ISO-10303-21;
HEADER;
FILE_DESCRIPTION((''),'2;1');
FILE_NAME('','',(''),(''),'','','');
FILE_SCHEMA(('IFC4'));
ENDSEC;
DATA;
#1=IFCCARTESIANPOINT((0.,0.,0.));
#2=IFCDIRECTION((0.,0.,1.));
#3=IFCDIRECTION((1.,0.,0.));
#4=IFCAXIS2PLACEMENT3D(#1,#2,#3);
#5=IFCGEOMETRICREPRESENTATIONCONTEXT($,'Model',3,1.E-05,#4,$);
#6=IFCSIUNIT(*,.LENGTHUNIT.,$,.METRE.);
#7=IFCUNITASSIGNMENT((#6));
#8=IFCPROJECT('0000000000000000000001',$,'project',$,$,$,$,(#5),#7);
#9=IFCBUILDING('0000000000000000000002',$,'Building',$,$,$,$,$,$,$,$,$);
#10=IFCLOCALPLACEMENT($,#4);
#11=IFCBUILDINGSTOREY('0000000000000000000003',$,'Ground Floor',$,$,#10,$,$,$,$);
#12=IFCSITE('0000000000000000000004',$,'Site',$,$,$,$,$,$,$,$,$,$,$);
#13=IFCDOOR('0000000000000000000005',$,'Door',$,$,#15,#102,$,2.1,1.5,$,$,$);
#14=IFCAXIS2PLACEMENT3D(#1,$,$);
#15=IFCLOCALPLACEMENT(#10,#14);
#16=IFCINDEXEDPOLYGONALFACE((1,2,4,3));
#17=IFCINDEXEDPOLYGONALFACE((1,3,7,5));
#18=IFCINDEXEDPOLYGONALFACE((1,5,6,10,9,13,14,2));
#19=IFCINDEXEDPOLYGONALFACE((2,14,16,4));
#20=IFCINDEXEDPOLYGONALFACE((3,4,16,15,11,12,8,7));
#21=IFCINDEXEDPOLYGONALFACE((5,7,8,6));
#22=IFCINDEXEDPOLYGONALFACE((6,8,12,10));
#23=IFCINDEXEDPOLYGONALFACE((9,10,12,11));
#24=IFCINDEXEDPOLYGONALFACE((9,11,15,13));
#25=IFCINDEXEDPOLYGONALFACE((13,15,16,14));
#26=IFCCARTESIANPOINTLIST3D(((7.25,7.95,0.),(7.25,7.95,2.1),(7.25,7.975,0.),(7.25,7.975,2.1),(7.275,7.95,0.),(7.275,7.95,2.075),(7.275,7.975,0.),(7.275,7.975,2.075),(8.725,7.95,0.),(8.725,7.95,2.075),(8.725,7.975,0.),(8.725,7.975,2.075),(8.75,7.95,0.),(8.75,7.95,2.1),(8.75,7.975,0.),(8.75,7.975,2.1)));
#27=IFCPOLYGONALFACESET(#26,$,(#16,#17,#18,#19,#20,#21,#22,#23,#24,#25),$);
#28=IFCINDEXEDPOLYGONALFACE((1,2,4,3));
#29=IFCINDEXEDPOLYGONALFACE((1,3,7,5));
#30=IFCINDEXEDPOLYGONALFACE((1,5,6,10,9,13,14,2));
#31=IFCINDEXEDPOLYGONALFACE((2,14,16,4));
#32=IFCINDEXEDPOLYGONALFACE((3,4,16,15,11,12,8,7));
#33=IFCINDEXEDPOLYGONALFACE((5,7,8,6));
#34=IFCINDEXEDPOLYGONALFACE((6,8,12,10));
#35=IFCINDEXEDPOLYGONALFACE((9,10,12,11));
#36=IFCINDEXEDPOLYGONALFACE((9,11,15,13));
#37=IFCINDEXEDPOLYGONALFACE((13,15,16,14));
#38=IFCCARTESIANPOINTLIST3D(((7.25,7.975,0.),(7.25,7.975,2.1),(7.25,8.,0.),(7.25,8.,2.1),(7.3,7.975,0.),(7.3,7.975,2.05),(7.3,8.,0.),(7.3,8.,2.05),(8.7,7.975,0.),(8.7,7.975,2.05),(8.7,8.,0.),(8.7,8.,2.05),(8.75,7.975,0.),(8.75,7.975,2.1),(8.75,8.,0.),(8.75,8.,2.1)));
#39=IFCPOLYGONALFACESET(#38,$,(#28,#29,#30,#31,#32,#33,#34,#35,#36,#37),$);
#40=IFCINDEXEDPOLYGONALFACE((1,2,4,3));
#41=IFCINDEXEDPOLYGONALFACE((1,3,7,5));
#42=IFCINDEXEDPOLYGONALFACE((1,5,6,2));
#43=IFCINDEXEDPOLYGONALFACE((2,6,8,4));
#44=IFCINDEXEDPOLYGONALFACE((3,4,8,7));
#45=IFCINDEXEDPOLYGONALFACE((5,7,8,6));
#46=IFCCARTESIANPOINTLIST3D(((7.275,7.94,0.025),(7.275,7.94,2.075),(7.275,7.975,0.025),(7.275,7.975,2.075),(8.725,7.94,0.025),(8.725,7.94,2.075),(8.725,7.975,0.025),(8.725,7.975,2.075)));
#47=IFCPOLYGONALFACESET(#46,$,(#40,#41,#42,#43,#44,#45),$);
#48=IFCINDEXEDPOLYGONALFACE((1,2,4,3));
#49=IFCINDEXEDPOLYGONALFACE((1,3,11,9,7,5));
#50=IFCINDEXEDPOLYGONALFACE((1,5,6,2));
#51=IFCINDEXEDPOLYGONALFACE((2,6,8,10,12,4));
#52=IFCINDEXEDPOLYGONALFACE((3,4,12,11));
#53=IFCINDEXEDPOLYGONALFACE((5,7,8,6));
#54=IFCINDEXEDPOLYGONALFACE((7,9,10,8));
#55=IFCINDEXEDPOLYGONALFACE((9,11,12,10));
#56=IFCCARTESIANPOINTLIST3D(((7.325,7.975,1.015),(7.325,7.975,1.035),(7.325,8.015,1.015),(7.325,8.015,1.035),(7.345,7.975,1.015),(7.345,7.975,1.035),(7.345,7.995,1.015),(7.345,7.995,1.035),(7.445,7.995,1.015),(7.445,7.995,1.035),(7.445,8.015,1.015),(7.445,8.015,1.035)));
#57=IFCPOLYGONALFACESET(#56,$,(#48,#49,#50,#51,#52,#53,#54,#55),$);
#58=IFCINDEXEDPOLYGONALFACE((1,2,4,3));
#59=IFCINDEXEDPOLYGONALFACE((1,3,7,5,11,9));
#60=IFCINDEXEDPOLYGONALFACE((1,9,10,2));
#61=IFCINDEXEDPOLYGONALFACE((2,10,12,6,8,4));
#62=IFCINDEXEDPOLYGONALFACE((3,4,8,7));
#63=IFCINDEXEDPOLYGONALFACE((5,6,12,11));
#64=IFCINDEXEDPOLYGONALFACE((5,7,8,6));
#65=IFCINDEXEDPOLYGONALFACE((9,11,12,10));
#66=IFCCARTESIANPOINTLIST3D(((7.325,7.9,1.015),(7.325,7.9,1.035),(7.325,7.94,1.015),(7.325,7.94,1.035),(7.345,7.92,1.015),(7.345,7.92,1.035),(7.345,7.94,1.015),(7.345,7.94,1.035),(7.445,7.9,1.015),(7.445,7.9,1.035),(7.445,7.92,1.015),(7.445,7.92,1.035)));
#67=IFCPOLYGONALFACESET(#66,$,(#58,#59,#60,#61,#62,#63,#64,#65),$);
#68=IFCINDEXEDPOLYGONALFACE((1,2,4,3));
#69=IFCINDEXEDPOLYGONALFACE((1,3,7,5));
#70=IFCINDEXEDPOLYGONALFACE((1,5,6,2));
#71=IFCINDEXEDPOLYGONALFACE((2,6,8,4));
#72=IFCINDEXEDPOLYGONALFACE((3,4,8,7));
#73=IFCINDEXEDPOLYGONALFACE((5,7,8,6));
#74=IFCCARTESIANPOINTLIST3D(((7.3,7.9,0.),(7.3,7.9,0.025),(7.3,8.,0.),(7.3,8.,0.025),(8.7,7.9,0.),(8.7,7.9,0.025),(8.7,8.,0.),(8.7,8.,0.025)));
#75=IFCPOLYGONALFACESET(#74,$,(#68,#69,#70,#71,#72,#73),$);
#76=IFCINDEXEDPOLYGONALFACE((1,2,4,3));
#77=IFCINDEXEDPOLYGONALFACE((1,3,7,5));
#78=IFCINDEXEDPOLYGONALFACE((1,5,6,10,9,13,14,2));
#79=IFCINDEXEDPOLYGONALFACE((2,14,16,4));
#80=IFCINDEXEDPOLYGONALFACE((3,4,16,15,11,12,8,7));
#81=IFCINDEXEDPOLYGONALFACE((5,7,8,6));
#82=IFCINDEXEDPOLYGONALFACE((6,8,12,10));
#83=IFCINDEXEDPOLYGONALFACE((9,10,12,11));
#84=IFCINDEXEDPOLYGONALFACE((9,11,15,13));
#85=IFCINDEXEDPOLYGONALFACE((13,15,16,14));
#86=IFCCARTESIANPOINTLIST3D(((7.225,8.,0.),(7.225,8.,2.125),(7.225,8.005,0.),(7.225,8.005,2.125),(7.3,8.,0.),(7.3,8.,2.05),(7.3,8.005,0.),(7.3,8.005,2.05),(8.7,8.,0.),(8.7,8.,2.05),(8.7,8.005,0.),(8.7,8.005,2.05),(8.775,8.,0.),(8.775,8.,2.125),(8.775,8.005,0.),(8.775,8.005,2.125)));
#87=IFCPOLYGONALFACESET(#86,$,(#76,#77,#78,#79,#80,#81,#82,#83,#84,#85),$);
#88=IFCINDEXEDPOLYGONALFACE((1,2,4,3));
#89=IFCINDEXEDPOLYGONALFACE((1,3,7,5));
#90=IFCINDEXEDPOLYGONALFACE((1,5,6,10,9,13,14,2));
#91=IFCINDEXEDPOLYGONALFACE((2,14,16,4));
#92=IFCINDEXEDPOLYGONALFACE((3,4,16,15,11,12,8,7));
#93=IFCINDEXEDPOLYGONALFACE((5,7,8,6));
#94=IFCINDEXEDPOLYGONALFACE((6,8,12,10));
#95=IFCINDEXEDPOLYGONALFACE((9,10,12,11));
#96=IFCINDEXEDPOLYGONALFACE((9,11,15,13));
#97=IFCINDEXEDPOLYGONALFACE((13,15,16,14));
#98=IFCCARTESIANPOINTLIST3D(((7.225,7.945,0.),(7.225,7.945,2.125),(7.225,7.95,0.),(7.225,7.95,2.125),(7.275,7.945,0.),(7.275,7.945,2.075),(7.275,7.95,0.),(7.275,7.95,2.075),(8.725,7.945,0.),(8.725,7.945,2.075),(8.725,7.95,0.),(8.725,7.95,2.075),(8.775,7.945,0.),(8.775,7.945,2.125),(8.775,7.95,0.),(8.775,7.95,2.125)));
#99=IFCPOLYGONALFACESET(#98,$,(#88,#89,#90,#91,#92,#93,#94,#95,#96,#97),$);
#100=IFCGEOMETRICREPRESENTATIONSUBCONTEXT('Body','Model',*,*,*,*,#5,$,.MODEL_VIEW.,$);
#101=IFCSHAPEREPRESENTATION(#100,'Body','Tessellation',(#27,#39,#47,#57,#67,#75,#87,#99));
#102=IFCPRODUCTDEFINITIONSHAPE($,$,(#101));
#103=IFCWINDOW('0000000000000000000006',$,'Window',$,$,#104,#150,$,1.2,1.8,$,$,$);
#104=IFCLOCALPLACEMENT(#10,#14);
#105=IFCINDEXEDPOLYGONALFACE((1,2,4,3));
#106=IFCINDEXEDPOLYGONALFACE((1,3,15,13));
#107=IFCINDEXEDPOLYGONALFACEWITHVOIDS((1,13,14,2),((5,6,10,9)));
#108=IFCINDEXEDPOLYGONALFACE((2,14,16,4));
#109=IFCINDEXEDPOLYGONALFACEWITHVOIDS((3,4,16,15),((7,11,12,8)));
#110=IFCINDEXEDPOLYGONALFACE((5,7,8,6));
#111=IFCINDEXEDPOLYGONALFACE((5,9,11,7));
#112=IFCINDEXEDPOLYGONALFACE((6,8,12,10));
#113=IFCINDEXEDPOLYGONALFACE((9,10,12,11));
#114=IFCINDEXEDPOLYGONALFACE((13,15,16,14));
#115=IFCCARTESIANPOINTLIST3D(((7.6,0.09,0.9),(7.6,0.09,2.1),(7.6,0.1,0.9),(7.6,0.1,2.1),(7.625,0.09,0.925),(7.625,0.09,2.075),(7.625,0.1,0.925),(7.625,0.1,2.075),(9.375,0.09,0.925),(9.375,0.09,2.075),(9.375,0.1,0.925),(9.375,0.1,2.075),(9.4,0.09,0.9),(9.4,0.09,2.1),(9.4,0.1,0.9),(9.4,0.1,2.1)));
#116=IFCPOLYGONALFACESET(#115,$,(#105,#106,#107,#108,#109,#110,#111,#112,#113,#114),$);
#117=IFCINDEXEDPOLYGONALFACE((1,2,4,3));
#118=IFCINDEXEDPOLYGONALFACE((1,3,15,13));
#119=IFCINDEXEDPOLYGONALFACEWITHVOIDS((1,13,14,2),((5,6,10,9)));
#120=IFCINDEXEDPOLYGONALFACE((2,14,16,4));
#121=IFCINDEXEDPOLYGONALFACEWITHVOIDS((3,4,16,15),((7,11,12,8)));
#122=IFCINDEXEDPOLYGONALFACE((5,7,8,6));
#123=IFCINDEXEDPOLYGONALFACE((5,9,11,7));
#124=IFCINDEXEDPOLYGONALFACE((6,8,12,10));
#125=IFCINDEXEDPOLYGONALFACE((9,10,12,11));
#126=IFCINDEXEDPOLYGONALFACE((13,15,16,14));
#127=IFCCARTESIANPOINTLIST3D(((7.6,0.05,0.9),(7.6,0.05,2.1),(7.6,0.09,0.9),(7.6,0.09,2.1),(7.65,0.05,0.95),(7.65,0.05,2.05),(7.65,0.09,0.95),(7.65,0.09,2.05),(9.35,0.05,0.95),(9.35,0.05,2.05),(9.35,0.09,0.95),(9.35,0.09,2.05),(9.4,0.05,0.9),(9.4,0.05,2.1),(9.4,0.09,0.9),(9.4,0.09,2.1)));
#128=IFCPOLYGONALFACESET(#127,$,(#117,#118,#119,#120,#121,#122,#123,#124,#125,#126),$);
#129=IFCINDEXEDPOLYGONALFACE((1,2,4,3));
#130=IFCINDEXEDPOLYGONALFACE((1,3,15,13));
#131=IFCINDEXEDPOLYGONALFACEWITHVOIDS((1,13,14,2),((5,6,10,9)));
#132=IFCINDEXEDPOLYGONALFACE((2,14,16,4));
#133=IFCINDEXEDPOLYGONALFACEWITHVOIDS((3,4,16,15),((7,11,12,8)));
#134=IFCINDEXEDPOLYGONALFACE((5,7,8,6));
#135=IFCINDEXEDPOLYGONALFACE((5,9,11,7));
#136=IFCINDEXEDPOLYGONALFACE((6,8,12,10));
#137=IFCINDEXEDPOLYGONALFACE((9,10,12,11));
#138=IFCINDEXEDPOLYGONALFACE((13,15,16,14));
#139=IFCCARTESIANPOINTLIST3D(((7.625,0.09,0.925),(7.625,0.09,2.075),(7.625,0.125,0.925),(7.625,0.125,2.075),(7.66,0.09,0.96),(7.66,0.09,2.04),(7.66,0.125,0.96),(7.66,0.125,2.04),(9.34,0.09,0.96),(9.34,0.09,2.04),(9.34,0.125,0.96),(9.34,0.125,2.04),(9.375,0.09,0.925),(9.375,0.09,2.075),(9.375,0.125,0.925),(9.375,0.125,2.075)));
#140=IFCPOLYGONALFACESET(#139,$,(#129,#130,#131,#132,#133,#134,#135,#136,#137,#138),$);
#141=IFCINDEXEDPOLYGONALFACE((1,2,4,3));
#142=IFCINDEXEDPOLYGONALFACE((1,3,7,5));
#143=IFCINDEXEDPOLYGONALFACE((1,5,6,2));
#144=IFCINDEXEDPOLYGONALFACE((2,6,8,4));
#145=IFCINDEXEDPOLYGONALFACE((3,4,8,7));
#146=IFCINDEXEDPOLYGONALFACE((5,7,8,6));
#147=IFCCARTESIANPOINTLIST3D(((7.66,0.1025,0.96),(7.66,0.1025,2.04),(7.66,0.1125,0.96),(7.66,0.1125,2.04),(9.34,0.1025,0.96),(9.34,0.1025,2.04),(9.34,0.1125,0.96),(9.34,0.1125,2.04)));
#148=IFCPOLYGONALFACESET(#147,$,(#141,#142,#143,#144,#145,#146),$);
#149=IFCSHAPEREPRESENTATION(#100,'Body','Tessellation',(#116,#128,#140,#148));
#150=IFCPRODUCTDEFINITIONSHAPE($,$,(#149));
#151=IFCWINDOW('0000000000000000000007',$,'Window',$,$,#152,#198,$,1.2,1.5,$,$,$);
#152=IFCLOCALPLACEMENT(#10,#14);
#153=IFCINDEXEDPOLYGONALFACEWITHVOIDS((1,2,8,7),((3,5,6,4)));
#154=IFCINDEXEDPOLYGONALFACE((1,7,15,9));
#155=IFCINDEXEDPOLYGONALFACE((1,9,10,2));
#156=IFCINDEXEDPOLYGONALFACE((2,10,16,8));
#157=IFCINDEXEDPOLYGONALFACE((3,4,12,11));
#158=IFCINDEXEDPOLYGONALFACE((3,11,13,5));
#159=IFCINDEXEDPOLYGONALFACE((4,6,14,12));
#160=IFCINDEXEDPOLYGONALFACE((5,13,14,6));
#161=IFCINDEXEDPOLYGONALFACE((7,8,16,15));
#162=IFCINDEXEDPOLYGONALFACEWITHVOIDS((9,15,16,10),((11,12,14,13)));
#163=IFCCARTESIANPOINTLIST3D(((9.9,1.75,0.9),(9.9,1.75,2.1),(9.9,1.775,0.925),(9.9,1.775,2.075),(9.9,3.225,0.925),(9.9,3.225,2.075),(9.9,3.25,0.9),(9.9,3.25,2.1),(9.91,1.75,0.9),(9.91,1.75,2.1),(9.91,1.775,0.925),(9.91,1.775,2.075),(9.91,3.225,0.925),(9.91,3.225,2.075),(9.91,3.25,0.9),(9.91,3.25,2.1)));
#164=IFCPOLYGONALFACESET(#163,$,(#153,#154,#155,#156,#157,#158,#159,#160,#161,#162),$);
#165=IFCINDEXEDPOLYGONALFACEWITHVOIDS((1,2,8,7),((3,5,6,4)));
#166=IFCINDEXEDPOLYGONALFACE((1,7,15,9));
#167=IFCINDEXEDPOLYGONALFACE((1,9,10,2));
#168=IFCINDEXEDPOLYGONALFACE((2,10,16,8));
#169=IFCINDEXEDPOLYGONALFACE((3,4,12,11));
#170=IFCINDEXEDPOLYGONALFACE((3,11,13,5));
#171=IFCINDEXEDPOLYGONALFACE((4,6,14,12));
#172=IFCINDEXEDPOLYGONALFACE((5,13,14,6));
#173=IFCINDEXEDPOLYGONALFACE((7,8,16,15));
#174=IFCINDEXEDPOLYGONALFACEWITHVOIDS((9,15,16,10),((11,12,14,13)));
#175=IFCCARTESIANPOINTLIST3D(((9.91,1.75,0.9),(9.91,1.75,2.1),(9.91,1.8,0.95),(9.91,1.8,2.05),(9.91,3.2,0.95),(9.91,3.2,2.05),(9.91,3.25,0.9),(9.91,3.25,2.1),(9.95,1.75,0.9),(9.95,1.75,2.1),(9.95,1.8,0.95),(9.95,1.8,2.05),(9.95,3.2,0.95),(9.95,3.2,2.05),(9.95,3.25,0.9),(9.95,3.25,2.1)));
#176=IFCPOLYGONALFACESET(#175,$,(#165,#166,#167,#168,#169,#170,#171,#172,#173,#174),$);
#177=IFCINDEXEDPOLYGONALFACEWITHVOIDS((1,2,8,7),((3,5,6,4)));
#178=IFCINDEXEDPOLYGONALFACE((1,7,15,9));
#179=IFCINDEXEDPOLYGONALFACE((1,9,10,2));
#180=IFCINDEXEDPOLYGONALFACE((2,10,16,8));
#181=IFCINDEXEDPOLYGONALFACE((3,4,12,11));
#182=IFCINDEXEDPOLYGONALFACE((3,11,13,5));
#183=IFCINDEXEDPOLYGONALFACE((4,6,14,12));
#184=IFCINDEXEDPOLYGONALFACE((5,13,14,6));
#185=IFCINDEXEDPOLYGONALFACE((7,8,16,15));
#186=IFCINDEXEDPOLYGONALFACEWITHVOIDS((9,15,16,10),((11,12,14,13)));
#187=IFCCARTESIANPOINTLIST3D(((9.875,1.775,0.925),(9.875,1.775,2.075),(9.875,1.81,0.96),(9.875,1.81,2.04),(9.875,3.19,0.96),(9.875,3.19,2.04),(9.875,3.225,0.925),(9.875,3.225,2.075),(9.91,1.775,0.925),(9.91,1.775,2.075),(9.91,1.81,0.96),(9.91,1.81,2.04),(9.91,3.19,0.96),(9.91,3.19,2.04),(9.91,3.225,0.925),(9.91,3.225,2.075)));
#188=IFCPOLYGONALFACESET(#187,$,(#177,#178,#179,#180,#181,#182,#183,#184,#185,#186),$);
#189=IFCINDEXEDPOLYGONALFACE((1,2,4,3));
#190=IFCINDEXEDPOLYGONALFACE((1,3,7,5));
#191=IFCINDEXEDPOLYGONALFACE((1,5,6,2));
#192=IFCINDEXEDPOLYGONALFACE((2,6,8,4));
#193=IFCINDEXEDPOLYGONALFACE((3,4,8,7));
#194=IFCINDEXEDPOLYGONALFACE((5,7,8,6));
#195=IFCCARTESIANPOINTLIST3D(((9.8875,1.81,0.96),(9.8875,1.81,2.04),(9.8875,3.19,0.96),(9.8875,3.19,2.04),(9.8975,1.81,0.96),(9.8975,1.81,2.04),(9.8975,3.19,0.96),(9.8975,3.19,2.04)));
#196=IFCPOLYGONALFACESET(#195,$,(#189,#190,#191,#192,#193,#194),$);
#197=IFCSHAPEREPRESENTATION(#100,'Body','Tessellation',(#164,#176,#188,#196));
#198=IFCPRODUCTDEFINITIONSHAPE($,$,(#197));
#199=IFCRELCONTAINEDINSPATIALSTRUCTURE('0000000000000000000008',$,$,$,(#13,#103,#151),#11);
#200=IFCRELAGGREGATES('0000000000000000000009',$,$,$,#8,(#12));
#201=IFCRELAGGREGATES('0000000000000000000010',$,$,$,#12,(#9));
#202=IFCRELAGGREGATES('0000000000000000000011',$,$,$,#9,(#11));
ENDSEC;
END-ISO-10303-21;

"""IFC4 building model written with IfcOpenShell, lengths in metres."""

from ifc_helpers import new_model, si_unit, frame, origin_with_axes, place, context, subcontext, project, spatial, line, indexed_curve, outline, extrude, element, save


model = new_model("IFC4")

# Units and contexts
model_context = context("Model", 3, precision=1e-05, world=origin_with_axes())
body_context = subcontext(model_context, "Body", "Model", "MODEL_VIEW")
ifc_project = project(units=[si_unit("LENGTHUNIT", "METRE")], contexts=[model_context])

# Site, building, storey
site = spatial("IfcSite", under=ifc_project, Name="Site")
building = spatial("IfcBuilding", under=site, Name="Building")
storey_placement = place(None, origin_with_axes())
storey = spatial("IfcBuildingStorey", under=building, at=storey_placement, Name="Ground Floor")

# Door
door_1_placement = place(storey_placement, frame((8.75, 8.0, 0.0), z_axis=(0.0, 0.0, 1.0), x_axis=(-1.0, 0.0, 0.0)))
element("IfcDoor", 1, at=door_1_placement, inside=storey, Name="Door", OverallHeight=2.1, OverallWidth=1.5, context=body_context, shape_type="SweptSolid", body=[
    extrude(outline(indexed_curve([(0.0, 0.0), (0.0, 2.1), (1.5, 2.1), (1.5, 0.0), (1.475, 0.0), (1.475, 2.075), (0.025, 2.075), (0.025, 0.0)], segments=[line(1, 2, 3, 4, 5, 6, 7, 8, 1)])), frame((0.0, 0.025, 0.0), z_axis=(0.0, -1.0, 0.0), x_axis=(1.0, 0.0, 0.0)), (0.0, 0.0, -1.0), 0.025),
    extrude(outline(indexed_curve([(0.0, 0.0), (0.0, 2.1), (1.5, 2.1), (1.5, 0.0), (1.45, 0.0), (1.45, 2.05), (0.05, 2.05), (0.05, 0.0)], segments=[line(1, 2, 3, 4, 5, 6, 7, 8, 1)])), frame((0.0, 0.0, 0.0), z_axis=(0.0, -1.0, 0.0), x_axis=(1.0, 0.0, 0.0)), (0.0, 0.0, -1.0), 0.025),
    extrude(outline(indexed_curve([(0.0, 0.0), (1.45, 0.0), (1.45, 0.035), (0.0, 0.035)], segments=[line(1, 2, 3, 4, 1)])), frame((0.025, 0.025, 0.025), z_axis=(0.0, 0.0, 1.0), x_axis=(1.0, 0.0, 0.0)), (0.0, 0.0, 1.0), 2.05),
    extrude(outline(indexed_curve([(0.0, 0.0), (0.0, -0.04), (-0.12, -0.04), (-0.12, -0.02), (-0.02, -0.02), (-0.02, 0.0)], segments=[line(1, 2, 3, 4, 5, 6, 1)])), frame((1.425, 0.025, 1.015), z_axis=(0.0, 0.0, 1.0), x_axis=(1.0, 0.0, 0.0)), (0.0, 0.0, 1.0), 0.02),
    extrude(outline(indexed_curve([(0.0, 0.0), (0.0, 0.04), (-0.12, 0.04), (-0.12, 0.02), (-0.02, 0.02), (-0.02, 0.0)], segments=[line(1, 2, 3, 4, 5, 6, 1)])), frame((1.425, 0.06, 1.015), z_axis=(0.0, 0.0, 1.0), x_axis=(1.0, 0.0, 0.0)), (0.0, 0.0, 1.0), 0.02),
    extrude(outline(indexed_curve([(0.0, 0.0), (1.4, 0.0), (1.4, 0.1), (0.0, 0.1)], segments=[line(1, 2, 3, 4, 1)])), frame((0.05, 0.0, 0.0), z_axis=(0.0, 0.0, 1.0), x_axis=(1.0, 0.0, 0.0)), (0.0, 0.0, 1.0), 0.025),
    extrude(outline(indexed_curve([(0.0, 0.0), (0.0, 2.125), (1.55, 2.125), (1.55, 0.0), (1.475, 0.0), (1.475, 2.05), (0.075, 2.05), (0.075, 0.0)], segments=[line(1, 2, 3, 4, 5, 6, 7, 8, 1)])), frame((-0.025, -0.005, 0.0), z_axis=(0.0, -1.0, 0.0), x_axis=(1.0, 0.0, 0.0)), (0.0, 0.0, -1.0), 0.005),
    extrude(outline(indexed_curve([(0.0, 0.0), (0.0, 2.125), (1.55, 2.125), (1.55, 0.0), (1.5, 0.0), (1.5, 2.075), (0.05, 2.075), (0.05, 0.0)], segments=[line(1, 2, 3, 4, 5, 6, 7, 8, 1)])), frame((-0.025, 0.05, 0.0), z_axis=(0.0, -1.0, 0.0), x_axis=(1.0, 0.0, 0.0)), (0.0, 0.0, -1.0), 0.005),
])

# Windows
window_1_placement = place(storey_placement, frame((7.6, 0.0, 0.9), z_axis=(0.0, 0.0, 1.0), x_axis=(1.0, 0.0, 0.0)))
element("IfcWindow", 2, at=window_1_placement, inside=storey, Name="Window", OverallHeight=1.2, OverallWidth=1.8, context=body_context, shape_type="SweptSolid", body=[
    extrude(outline(indexed_curve([(0.0, 0.0), (1.8, 0.0), (1.8, 1.2), (0.0, 1.2)], segments=[line(1, 2, 3, 4, 1)]), holes=[indexed_curve([(0.025, 0.025), (1.775, 0.025), (1.775, 1.175), (0.025, 1.175)], segments=[line(1, 2, 3, 4, 1)])]), frame((0.0, 0.09, 0.0), z_axis=(0.0, -1.0, 0.0), x_axis=(1.0, 0.0, 0.0)), (0.0, 0.0, -1.0), 0.01),
    extrude(outline(indexed_curve([(0.0, 0.0), (1.8, 0.0), (1.8, 1.2), (0.0, 1.2)], segments=[line(1, 2, 3, 4, 1)]), holes=[indexed_curve([(0.05, 0.05), (1.75, 0.05), (1.75, 1.15), (0.05, 1.15)], segments=[line(1, 2, 3, 4, 1)])]), frame((0.0, 0.05, 0.0), z_axis=(0.0, -1.0, 0.0), x_axis=(1.0, 0.0, 0.0)), (0.0, 0.0, -1.0), 0.04),
    extrude(outline(indexed_curve([(0.0, 0.0), (1.75, 0.0), (1.75, 1.15), (0.0, 1.15)], segments=[line(1, 2, 3, 4, 1)]), holes=[indexed_curve([(0.035, 0.035), (1.715, 0.035), (1.715, 1.115), (0.035, 1.115)], segments=[line(1, 2, 3, 4, 1)])]), frame((0.025, 0.09, 0.025), z_axis=(0.0, -1.0, 0.0), x_axis=(1.0, 0.0, 0.0)), (0.0, 0.0, -1.0), 0.035),
    extrude(outline(indexed_curve([(0.035, 0.035), (1.715, 0.035), (1.715, 1.115), (0.035, 1.115)], segments=[line(1, 2, 3, 4, 1)])), frame((0.025, 0.1025, 0.025), z_axis=(0.0, -1.0, 0.0), x_axis=(1.0, 0.0, 0.0)), (0.0, 0.0, -1.0), 0.01),
])
window_2_placement = place(storey_placement, frame((10.0, 1.75, 0.9), z_axis=(0.0, 0.0, 1.0), x_axis=(0.0, 1.0, 0.0)))
element("IfcWindow", 3, at=window_2_placement, inside=storey, Name="Window", OverallHeight=1.2, OverallWidth=1.5, context=body_context, shape_type="SweptSolid", body=[
    extrude(outline(indexed_curve([(0.0, 0.0), (1.5, 0.0), (1.5, 1.2), (0.0, 1.2)], segments=[line(1, 2, 3, 4, 1)]), holes=[indexed_curve([(0.025, 0.025), (1.475, 0.025), (1.475, 1.175), (0.025, 1.175)], segments=[line(1, 2, 3, 4, 1)])]), frame((0.0, 0.09, 0.0), z_axis=(0.0, -1.0, 0.0), x_axis=(1.0, 0.0, 0.0)), (0.0, 0.0, -1.0), 0.01),
    extrude(outline(indexed_curve([(0.0, 0.0), (1.5, 0.0), (1.5, 1.2), (0.0, 1.2)], segments=[line(1, 2, 3, 4, 1)]), holes=[indexed_curve([(0.05, 0.05), (1.45, 0.05), (1.45, 1.15), (0.05, 1.15)], segments=[line(1, 2, 3, 4, 1)])]), frame((0.0, 0.05, 0.0), z_axis=(0.0, -1.0, 0.0), x_axis=(1.0, 0.0, 0.0)), (0.0, 0.0, -1.0), 0.04),
    extrude(outline(indexed_curve([(0.0, 0.0), (1.45, 0.0), (1.45, 1.15), (0.0, 1.15)], segments=[line(1, 2, 3, 4, 1)]), holes=[indexed_curve([(0.035, 0.035), (1.415, 0.035), (1.415, 1.115), (0.035, 1.115)], segments=[line(1, 2, 3, 4, 1)])]), frame((0.025, 0.09, 0.025), z_axis=(0.0, -1.0, 0.0), x_axis=(1.0, 0.0, 0.0)), (0.0, 0.0, -1.0), 0.035),
    extrude(outline(indexed_curve([(0.035, 0.035), (1.415, 0.035), (1.415, 1.115), (0.035, 1.115)], segments=[line(1, 2, 3, 4, 1)])), frame((0.025, 0.1025, 0.025), z_axis=(0.0, -1.0, 0.0), x_axis=(1.0, 0.0, 0.0)), (0.0, 0.0, -1.0), 0.01),
])

save(model, "model.ifc")
